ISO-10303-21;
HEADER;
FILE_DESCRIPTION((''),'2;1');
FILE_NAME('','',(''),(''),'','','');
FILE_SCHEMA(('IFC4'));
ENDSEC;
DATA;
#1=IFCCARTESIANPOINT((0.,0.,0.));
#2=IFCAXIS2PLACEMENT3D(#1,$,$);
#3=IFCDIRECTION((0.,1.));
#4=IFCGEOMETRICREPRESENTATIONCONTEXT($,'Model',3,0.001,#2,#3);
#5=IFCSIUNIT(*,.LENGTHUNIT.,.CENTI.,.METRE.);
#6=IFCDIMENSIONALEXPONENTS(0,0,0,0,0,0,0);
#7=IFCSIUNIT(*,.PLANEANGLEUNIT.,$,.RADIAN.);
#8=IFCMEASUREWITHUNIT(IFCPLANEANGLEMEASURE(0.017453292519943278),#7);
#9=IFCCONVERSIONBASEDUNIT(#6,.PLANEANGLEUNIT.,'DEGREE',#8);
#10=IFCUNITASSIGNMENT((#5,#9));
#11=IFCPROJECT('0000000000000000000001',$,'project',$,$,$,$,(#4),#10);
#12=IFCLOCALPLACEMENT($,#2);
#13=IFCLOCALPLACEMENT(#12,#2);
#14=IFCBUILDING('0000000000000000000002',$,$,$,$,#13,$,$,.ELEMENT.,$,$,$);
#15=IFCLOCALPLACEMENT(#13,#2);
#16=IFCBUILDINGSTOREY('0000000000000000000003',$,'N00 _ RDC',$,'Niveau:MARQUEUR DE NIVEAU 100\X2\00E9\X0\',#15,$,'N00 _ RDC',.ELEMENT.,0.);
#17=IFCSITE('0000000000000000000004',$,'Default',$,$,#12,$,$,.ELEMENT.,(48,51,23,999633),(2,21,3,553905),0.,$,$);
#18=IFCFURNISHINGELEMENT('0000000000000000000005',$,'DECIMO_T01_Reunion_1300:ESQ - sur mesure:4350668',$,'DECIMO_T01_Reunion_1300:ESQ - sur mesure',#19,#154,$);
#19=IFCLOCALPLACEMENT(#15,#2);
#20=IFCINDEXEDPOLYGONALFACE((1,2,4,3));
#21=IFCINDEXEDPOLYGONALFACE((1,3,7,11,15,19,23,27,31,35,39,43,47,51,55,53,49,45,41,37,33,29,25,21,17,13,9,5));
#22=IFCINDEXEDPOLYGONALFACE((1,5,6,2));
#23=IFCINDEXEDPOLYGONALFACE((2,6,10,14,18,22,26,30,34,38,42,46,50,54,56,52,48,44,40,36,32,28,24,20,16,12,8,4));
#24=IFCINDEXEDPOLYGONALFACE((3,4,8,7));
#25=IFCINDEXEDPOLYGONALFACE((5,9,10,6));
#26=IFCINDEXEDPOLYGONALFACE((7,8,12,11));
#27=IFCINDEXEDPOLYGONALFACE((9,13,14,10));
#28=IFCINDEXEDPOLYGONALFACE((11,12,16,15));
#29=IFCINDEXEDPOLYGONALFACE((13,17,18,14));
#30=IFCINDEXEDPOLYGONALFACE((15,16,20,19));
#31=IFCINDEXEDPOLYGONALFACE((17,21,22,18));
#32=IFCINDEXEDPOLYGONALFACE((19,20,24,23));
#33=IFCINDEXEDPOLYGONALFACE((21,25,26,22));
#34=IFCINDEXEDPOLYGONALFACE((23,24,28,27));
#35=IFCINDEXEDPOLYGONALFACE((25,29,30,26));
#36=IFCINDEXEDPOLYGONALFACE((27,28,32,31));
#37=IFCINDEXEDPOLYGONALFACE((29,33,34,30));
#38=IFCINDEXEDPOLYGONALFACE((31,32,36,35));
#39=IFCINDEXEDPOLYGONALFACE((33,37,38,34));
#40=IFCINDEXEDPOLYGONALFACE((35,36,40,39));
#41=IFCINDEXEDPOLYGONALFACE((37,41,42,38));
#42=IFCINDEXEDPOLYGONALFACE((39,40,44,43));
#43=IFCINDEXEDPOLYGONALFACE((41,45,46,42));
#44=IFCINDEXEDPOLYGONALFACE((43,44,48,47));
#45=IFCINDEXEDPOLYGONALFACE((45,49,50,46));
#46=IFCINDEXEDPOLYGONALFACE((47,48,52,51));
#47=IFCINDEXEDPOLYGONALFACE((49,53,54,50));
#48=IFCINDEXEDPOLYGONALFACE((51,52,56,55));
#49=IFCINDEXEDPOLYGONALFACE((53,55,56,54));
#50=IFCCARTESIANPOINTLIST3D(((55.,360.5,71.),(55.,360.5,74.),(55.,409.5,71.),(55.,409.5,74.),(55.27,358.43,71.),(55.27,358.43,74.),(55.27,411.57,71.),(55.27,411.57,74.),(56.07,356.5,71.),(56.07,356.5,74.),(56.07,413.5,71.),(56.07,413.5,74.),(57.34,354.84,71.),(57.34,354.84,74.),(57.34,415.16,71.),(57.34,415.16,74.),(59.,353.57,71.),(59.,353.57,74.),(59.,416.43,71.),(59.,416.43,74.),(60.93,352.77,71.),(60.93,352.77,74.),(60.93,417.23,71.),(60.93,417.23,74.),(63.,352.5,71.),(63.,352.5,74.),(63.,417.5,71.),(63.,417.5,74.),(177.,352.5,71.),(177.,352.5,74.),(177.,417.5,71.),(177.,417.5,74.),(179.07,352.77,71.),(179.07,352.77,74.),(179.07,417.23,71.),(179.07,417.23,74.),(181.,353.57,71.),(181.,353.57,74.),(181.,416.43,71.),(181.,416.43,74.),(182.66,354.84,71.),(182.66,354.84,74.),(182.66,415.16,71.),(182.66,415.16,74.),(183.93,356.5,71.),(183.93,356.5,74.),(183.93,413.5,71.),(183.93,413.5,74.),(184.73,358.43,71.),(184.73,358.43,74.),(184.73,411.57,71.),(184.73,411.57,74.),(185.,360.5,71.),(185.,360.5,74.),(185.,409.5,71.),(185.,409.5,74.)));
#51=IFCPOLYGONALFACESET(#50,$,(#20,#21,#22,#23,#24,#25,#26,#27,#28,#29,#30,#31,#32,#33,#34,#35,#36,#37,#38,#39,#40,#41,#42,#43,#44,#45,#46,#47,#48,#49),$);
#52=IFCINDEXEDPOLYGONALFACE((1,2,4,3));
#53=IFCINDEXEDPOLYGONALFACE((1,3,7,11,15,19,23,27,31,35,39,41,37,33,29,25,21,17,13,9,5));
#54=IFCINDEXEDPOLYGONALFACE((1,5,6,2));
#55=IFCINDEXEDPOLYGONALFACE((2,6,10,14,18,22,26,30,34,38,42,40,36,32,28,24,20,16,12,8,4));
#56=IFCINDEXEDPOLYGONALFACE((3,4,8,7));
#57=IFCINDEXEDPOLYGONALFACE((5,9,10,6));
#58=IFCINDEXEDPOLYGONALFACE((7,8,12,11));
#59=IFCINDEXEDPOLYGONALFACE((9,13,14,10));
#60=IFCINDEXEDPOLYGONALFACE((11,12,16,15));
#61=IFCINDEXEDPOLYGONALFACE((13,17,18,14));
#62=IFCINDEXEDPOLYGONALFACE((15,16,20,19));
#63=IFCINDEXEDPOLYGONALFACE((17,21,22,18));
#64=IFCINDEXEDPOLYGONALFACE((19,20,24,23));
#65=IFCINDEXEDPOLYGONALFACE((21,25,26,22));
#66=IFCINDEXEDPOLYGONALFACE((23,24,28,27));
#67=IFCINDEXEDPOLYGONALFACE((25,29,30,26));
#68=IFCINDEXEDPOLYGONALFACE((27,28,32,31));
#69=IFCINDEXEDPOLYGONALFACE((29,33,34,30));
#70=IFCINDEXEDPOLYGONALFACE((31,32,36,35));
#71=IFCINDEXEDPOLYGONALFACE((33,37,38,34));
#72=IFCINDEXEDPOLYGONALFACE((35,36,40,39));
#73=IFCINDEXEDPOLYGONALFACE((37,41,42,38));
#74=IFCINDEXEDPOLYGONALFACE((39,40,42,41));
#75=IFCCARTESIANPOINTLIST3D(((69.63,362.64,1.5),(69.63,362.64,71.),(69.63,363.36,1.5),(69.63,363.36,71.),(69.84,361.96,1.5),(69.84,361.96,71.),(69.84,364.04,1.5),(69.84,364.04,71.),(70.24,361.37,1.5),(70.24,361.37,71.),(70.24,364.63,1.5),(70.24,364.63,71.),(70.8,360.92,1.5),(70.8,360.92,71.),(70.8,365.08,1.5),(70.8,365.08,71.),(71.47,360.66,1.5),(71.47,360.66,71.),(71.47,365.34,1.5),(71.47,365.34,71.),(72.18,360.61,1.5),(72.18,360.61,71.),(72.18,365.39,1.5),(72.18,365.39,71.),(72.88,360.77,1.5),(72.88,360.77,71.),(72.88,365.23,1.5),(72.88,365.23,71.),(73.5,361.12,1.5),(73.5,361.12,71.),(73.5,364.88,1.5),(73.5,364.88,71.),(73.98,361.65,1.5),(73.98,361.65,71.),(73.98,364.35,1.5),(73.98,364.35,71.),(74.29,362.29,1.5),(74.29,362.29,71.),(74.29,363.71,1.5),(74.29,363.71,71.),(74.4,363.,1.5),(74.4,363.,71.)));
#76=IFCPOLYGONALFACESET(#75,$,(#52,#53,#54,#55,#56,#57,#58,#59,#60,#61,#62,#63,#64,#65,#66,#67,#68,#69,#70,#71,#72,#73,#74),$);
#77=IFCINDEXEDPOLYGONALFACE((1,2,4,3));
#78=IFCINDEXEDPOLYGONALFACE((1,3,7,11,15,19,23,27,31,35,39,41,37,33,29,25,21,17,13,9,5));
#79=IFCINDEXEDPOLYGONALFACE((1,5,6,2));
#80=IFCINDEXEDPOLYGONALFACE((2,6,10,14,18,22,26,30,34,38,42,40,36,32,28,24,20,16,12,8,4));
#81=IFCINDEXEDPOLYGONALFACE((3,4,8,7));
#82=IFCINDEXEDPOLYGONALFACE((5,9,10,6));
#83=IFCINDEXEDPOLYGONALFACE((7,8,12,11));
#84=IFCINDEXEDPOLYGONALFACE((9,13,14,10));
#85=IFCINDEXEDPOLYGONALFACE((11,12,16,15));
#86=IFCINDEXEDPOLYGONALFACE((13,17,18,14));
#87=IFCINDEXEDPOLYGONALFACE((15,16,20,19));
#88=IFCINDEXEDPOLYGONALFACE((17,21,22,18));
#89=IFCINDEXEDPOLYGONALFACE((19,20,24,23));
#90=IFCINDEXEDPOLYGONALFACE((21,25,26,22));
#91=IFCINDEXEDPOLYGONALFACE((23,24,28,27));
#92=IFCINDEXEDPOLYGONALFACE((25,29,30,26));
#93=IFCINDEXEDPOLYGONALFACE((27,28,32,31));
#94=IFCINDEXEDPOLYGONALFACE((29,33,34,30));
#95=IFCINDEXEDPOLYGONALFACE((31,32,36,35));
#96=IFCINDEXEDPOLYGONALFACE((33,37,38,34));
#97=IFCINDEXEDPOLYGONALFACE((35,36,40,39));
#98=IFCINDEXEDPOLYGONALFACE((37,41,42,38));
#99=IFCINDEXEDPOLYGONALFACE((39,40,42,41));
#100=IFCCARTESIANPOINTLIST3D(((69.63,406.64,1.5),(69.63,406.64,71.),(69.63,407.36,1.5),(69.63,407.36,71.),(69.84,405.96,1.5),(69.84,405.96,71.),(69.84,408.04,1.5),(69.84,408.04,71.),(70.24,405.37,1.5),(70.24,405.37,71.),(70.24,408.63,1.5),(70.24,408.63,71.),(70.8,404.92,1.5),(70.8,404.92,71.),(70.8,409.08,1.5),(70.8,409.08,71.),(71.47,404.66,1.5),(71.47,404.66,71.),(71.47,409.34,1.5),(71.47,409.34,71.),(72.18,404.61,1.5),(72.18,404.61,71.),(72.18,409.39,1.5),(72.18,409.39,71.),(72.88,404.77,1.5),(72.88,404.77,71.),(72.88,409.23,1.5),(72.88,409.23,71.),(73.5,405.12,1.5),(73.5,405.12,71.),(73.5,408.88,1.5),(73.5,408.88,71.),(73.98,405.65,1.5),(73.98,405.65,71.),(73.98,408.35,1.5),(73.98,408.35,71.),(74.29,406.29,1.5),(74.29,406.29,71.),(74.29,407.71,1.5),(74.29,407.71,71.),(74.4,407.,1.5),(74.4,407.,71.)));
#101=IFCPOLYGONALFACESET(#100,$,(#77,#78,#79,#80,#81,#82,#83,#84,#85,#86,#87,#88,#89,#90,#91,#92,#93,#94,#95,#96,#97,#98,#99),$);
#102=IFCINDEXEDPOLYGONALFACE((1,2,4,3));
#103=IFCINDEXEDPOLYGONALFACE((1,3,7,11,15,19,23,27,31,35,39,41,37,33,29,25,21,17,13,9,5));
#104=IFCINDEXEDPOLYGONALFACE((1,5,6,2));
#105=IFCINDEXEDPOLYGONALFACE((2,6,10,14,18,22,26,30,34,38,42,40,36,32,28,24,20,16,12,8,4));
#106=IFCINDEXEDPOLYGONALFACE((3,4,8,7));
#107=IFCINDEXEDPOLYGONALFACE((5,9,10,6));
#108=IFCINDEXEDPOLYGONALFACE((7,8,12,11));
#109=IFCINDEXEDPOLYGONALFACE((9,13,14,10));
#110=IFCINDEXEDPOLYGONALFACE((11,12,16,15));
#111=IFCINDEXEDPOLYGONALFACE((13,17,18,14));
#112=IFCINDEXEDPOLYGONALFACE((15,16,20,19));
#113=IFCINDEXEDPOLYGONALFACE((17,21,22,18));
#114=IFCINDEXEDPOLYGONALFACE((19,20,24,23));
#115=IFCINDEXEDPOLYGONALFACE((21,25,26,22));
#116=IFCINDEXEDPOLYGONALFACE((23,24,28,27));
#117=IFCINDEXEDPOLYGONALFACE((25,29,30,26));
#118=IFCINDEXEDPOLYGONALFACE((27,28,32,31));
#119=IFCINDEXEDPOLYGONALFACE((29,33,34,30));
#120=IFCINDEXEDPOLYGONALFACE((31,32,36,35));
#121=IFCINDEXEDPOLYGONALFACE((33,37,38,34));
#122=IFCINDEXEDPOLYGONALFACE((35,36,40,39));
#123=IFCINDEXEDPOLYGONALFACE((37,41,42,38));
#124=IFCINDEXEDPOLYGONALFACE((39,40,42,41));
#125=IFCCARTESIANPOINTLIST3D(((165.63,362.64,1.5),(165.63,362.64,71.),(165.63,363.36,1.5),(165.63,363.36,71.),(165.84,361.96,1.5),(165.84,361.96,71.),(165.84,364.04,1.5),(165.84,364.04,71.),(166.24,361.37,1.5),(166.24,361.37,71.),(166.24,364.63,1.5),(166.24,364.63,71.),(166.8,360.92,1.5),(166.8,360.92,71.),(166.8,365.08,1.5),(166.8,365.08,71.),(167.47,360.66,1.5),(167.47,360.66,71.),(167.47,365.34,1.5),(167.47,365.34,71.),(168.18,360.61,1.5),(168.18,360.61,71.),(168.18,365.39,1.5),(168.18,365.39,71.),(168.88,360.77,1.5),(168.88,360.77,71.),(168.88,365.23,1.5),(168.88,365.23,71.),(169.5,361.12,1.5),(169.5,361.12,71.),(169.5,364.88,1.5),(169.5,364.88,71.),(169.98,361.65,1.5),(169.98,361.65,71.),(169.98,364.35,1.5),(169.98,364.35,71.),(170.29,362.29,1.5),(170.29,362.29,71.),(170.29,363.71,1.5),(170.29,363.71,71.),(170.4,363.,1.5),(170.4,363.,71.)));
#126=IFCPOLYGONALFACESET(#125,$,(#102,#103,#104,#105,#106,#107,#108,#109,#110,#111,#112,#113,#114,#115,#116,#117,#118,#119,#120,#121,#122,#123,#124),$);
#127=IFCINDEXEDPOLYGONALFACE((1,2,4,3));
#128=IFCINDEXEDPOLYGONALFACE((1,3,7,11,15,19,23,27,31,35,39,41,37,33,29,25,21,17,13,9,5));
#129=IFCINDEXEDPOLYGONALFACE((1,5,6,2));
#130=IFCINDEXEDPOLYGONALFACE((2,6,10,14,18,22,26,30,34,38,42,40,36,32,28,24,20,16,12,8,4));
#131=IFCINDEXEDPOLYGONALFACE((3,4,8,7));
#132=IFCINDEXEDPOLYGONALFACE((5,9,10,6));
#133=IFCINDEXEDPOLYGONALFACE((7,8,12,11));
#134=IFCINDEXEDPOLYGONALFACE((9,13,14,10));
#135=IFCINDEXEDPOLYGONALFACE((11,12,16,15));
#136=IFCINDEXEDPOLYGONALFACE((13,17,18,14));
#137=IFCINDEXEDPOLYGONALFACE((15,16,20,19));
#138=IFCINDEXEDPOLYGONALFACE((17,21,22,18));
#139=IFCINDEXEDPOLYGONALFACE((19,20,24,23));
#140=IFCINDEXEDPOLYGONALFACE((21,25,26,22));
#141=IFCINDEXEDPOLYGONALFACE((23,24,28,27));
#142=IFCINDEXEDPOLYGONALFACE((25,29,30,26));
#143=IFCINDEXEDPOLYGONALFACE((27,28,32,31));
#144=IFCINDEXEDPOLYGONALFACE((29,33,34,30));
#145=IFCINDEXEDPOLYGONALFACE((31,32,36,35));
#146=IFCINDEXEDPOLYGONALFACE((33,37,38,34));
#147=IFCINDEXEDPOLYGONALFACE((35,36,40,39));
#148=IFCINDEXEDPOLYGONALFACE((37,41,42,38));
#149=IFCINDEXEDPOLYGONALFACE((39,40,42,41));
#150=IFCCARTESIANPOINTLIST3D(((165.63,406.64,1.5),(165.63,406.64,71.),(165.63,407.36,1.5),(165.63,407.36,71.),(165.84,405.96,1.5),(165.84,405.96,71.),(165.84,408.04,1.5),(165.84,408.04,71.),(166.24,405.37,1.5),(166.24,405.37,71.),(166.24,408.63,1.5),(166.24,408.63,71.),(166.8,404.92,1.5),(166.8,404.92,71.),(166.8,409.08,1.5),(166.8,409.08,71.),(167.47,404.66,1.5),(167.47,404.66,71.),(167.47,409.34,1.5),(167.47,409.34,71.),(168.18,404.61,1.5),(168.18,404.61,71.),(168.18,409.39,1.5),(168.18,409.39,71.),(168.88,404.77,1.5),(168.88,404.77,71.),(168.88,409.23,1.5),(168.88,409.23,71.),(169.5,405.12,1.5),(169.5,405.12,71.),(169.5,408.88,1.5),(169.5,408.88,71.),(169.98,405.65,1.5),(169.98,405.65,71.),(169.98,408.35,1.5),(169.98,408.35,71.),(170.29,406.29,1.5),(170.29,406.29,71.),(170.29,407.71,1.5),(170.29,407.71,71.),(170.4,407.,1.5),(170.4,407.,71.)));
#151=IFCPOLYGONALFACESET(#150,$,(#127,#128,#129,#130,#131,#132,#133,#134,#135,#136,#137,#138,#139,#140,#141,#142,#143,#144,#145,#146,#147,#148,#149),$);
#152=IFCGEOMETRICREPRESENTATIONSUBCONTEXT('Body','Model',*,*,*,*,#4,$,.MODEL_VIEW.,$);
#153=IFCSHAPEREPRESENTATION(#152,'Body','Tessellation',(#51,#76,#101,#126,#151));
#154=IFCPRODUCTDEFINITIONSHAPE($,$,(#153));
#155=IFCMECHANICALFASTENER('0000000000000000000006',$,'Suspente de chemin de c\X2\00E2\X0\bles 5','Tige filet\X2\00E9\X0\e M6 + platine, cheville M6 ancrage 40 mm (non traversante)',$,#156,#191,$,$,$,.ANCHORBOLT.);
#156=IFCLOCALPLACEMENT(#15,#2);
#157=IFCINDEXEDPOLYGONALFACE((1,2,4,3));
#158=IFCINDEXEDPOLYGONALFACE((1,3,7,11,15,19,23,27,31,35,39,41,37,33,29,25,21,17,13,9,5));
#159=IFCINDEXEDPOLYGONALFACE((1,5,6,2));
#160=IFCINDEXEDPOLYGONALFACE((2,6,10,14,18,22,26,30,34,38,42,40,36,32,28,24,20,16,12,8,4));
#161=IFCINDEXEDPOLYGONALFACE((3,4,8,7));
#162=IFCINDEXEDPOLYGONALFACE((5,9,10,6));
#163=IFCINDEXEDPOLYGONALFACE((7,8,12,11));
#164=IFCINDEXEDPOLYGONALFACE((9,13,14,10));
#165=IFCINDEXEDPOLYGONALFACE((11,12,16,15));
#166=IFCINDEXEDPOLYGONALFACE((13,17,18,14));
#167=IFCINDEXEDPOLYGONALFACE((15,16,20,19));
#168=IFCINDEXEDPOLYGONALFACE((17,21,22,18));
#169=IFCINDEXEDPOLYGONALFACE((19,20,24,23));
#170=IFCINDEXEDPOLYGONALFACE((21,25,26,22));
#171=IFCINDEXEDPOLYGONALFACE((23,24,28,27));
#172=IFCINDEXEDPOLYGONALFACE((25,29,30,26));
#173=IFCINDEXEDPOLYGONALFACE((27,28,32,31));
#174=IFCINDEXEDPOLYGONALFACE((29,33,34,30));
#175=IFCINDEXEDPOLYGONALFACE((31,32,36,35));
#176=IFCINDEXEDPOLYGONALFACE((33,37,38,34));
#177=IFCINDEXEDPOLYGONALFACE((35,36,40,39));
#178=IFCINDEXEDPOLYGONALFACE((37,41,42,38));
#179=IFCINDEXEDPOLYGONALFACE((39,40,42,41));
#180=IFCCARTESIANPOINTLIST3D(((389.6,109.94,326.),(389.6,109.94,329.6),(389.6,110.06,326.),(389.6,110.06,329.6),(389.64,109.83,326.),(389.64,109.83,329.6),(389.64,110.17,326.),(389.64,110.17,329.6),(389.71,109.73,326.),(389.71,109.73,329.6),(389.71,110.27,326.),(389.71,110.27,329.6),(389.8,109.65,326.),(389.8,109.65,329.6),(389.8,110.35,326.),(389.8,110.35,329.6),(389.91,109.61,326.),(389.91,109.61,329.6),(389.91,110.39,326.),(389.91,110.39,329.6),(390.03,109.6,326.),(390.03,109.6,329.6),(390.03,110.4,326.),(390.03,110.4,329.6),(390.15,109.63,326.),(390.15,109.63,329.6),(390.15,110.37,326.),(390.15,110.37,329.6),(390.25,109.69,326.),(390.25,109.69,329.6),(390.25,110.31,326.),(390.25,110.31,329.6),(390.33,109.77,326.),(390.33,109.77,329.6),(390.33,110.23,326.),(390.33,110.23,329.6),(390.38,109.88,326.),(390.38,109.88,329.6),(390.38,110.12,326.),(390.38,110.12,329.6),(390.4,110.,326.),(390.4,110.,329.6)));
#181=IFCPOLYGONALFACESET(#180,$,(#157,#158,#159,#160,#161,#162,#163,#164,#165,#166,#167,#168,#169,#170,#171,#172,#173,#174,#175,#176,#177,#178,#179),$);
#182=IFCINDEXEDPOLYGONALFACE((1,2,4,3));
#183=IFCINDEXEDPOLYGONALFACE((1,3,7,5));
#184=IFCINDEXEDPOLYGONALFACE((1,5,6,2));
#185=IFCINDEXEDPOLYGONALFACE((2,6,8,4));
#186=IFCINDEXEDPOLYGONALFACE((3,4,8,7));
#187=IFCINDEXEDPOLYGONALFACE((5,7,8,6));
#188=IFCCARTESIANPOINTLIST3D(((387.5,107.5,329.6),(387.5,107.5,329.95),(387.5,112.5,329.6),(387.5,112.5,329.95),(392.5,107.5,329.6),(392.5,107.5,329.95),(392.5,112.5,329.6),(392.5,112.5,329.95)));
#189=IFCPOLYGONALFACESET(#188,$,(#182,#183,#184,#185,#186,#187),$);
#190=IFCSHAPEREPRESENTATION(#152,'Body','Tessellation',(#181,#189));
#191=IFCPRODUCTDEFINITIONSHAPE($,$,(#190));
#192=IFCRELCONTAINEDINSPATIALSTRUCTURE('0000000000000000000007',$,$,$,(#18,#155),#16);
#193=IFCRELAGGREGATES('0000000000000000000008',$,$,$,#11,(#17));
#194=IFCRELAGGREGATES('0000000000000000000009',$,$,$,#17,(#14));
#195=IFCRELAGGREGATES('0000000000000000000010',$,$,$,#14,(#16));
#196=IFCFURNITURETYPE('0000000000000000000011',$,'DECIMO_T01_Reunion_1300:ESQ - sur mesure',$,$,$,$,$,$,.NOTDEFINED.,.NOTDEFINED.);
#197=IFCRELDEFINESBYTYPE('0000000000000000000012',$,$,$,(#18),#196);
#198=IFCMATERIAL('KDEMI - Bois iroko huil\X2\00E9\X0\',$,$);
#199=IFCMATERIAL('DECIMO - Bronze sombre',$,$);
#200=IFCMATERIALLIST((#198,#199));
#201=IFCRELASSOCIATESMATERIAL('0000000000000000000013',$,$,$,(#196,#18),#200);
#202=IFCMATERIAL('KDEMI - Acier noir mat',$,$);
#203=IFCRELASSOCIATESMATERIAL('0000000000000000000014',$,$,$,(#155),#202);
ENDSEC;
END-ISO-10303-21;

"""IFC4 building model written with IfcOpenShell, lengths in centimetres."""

from ifc_helpers import new_model, entity, si_unit, converted_unit, direction, frame, frame_2d, origin, origin_with_axes, origin_2d_with_axis, place, context, subcontext, project, spatial, polyline, circle_curve, parameter, trimmed, segment, composite_curve, rectangle, circle, outline, extrude, source, transform, mapped, material, material_list, type_object, type_shapes, element, save


model = new_model("IFC4")

# Units and contexts
model_context = context("Model", 3, precision=0.001, world=origin(), true_north=direction((0.0, 1.0)))
body_context = subcontext(model_context, "Body", "Model", "MODEL_VIEW")
ifc_project = project(units=[si_unit("LENGTHUNIT", "METRE", prefix="CENTI"), converted_unit("PLANEANGLEUNIT", "DEGREE", entity("IfcPlaneAngleMeasure", 0.017453292519943278), si_unit("PLANEANGLEUNIT", "RADIAN"), dimensions=[0, 0, 0, 0, 0, 0, 0])], contexts=[model_context])

# Site, building, storey
site_placement = place(None, origin())
site = spatial("IfcSite", under=ifc_project, at=site_placement, Name="Default", CompositionType="ELEMENT", RefLatitude=(48, 51, 23, 999633), RefLongitude=(2, 21, 3, 553905), RefElevation=0.0)
building_placement = place(site_placement, origin())
building = spatial("IfcBuilding", under=site, at=building_placement, CompositionType="ELEMENT")
storey_placement = place(building_placement, origin())
storey = spatial("IfcBuildingStorey", under=building, at=storey_placement, Name="N00 _ RDC", ObjectType="Niveau:MARQUEUR DE NIVEAU 100é", LongName="N00 _ RDC", CompositionType="ELEMENT", Elevation=0.0)

# Shared definitions
ifc_material_1 = material(Name="KDEMI - Acier noir mat")

# Furnishing element
ifc_material_2 = material(Name="KDEMI - Bois iroko huilé")
ifc_material_3 = material(Name="DECIMO - Bronze sombre")
ifc_material_list_1 = material_list([ifc_material_2, ifc_material_3])
furniture_type_1 = type_object("IfcFurnitureType", Name="DECIMO_T01_Reunion_1300:ESQ - sur mesure", AssemblyPlace="NOTDEFINED", material=ifc_material_list_1)
shared_shape_1 = source(origin(), body_context, "Body", "SweptSolid", [
    extrude(outline(composite_curve([segment(polyline([(-57.0, -32.5), (57.0, -32.5)]), True, "CONTINUOUS"), segment(trimmed(circle_curve(frame_2d((57.0, -24.5), x_axis=(1.0, 0.0)), 8.0), [parameter(270.0)], [parameter(0.0)], True, "PARAMETER"), True, "CONTINUOUS"), segment(polyline([(65.0, -24.5), (65.0, 24.5)]), True, "CONTINUOUS"), segment(trimmed(circle_curve(frame_2d((57.0, 24.5), x_axis=(1.0, 0.0)), 8.0), [parameter(0.0)], [parameter(90.0)], True, "PARAMETER"), True, "CONTINUOUS"), segment(polyline([(57.0, 32.5), (-57.0, 32.5)]), True, "CONTINUOUS"), segment(trimmed(circle_curve(frame_2d((-57.0, 24.5), x_axis=(1.0, 0.0)), 8.0), [parameter(90.0)], [parameter(180.0)], True, "PARAMETER"), True, "CONTINUOUS"), segment(polyline([(-65.0, 24.5), (-65.0, -24.5)]), True, "CONTINUOUS"), segment(trimmed(circle_curve(frame_2d((-57.0, -24.5), x_axis=(1.0, 0.0)), 8.0), [parameter(180.0)], [parameter(270.0)], True, "PARAMETER"), True, "CONTINUOUS")], self_intersect=False)), frame((0.0, 0.0, 71.0)), (0.0, 0.0, 1.0), 3.0),
    extrude(circle(Radius=2.4, at=origin_2d_with_axis()), frame((-48.0, -22.0, 1.5)), (0.0, 0.0, 1.0), 69.5),
    extrude(circle(Radius=2.4, at=origin_2d_with_axis()), frame((-48.0, 22.0, 1.5)), (0.0, 0.0, 1.0), 69.5),
    extrude(circle(Radius=2.4, at=origin_2d_with_axis()), frame((48.0, -22.0, 1.5)), (0.0, 0.0, 1.0), 69.5),
    extrude(circle(Radius=2.4, at=origin_2d_with_axis()), frame((48.0, 22.0, 1.5)), (0.0, 0.0, 1.0), 69.5),
])
type_shapes(furniture_type_1, [shared_shape_1])
furnishing_1_placement = place(storey_placement, frame((120.0, 385.0, 0.0)))
element("IfcFurnishingElement", 1, at=furnishing_1_placement, inside=storey, type_object=furniture_type_1, material=ifc_material_list_1, Name="DECIMO_T01_Reunion_1300:ESQ - sur mesure:4350668", ObjectType="DECIMO_T01_Reunion_1300:ESQ - sur mesure", context=body_context, shape_type="MappedRepresentation", body=[
    mapped(shared_shape_1, transform((0.0, 0.0, 0.0), scale=1.0)),
])

# Mechanical fastener
mechanical_fastener_1_placement = place(storey_placement, origin_with_axes())
element("IfcMechanicalFastener", 2, at=mechanical_fastener_1_placement, inside=storey, material=ifc_material_1, Name="Suspente de chemin de câbles 5", Description="Tige filetée M6 + platine, cheville M6 ancrage 40 mm (non traversante)", PredefinedType="ANCHORBOLT", context=body_context, shape_type="SweptSolid", body=[
    extrude(circle(Radius=0.4, at=frame_2d((390.0, 110.0))), frame((0.0, 0.0, 326.0)), (0.0, 0.0, 1.0), 3.6),
    extrude(rectangle(XDim=5.0, YDim=5.0, at=frame_2d((390.0, 110.0))), frame((0.0, 0.0, 329.6)), (0.0, 0.0, 1.0), 0.35),
])

save(model, "model.ifc")
